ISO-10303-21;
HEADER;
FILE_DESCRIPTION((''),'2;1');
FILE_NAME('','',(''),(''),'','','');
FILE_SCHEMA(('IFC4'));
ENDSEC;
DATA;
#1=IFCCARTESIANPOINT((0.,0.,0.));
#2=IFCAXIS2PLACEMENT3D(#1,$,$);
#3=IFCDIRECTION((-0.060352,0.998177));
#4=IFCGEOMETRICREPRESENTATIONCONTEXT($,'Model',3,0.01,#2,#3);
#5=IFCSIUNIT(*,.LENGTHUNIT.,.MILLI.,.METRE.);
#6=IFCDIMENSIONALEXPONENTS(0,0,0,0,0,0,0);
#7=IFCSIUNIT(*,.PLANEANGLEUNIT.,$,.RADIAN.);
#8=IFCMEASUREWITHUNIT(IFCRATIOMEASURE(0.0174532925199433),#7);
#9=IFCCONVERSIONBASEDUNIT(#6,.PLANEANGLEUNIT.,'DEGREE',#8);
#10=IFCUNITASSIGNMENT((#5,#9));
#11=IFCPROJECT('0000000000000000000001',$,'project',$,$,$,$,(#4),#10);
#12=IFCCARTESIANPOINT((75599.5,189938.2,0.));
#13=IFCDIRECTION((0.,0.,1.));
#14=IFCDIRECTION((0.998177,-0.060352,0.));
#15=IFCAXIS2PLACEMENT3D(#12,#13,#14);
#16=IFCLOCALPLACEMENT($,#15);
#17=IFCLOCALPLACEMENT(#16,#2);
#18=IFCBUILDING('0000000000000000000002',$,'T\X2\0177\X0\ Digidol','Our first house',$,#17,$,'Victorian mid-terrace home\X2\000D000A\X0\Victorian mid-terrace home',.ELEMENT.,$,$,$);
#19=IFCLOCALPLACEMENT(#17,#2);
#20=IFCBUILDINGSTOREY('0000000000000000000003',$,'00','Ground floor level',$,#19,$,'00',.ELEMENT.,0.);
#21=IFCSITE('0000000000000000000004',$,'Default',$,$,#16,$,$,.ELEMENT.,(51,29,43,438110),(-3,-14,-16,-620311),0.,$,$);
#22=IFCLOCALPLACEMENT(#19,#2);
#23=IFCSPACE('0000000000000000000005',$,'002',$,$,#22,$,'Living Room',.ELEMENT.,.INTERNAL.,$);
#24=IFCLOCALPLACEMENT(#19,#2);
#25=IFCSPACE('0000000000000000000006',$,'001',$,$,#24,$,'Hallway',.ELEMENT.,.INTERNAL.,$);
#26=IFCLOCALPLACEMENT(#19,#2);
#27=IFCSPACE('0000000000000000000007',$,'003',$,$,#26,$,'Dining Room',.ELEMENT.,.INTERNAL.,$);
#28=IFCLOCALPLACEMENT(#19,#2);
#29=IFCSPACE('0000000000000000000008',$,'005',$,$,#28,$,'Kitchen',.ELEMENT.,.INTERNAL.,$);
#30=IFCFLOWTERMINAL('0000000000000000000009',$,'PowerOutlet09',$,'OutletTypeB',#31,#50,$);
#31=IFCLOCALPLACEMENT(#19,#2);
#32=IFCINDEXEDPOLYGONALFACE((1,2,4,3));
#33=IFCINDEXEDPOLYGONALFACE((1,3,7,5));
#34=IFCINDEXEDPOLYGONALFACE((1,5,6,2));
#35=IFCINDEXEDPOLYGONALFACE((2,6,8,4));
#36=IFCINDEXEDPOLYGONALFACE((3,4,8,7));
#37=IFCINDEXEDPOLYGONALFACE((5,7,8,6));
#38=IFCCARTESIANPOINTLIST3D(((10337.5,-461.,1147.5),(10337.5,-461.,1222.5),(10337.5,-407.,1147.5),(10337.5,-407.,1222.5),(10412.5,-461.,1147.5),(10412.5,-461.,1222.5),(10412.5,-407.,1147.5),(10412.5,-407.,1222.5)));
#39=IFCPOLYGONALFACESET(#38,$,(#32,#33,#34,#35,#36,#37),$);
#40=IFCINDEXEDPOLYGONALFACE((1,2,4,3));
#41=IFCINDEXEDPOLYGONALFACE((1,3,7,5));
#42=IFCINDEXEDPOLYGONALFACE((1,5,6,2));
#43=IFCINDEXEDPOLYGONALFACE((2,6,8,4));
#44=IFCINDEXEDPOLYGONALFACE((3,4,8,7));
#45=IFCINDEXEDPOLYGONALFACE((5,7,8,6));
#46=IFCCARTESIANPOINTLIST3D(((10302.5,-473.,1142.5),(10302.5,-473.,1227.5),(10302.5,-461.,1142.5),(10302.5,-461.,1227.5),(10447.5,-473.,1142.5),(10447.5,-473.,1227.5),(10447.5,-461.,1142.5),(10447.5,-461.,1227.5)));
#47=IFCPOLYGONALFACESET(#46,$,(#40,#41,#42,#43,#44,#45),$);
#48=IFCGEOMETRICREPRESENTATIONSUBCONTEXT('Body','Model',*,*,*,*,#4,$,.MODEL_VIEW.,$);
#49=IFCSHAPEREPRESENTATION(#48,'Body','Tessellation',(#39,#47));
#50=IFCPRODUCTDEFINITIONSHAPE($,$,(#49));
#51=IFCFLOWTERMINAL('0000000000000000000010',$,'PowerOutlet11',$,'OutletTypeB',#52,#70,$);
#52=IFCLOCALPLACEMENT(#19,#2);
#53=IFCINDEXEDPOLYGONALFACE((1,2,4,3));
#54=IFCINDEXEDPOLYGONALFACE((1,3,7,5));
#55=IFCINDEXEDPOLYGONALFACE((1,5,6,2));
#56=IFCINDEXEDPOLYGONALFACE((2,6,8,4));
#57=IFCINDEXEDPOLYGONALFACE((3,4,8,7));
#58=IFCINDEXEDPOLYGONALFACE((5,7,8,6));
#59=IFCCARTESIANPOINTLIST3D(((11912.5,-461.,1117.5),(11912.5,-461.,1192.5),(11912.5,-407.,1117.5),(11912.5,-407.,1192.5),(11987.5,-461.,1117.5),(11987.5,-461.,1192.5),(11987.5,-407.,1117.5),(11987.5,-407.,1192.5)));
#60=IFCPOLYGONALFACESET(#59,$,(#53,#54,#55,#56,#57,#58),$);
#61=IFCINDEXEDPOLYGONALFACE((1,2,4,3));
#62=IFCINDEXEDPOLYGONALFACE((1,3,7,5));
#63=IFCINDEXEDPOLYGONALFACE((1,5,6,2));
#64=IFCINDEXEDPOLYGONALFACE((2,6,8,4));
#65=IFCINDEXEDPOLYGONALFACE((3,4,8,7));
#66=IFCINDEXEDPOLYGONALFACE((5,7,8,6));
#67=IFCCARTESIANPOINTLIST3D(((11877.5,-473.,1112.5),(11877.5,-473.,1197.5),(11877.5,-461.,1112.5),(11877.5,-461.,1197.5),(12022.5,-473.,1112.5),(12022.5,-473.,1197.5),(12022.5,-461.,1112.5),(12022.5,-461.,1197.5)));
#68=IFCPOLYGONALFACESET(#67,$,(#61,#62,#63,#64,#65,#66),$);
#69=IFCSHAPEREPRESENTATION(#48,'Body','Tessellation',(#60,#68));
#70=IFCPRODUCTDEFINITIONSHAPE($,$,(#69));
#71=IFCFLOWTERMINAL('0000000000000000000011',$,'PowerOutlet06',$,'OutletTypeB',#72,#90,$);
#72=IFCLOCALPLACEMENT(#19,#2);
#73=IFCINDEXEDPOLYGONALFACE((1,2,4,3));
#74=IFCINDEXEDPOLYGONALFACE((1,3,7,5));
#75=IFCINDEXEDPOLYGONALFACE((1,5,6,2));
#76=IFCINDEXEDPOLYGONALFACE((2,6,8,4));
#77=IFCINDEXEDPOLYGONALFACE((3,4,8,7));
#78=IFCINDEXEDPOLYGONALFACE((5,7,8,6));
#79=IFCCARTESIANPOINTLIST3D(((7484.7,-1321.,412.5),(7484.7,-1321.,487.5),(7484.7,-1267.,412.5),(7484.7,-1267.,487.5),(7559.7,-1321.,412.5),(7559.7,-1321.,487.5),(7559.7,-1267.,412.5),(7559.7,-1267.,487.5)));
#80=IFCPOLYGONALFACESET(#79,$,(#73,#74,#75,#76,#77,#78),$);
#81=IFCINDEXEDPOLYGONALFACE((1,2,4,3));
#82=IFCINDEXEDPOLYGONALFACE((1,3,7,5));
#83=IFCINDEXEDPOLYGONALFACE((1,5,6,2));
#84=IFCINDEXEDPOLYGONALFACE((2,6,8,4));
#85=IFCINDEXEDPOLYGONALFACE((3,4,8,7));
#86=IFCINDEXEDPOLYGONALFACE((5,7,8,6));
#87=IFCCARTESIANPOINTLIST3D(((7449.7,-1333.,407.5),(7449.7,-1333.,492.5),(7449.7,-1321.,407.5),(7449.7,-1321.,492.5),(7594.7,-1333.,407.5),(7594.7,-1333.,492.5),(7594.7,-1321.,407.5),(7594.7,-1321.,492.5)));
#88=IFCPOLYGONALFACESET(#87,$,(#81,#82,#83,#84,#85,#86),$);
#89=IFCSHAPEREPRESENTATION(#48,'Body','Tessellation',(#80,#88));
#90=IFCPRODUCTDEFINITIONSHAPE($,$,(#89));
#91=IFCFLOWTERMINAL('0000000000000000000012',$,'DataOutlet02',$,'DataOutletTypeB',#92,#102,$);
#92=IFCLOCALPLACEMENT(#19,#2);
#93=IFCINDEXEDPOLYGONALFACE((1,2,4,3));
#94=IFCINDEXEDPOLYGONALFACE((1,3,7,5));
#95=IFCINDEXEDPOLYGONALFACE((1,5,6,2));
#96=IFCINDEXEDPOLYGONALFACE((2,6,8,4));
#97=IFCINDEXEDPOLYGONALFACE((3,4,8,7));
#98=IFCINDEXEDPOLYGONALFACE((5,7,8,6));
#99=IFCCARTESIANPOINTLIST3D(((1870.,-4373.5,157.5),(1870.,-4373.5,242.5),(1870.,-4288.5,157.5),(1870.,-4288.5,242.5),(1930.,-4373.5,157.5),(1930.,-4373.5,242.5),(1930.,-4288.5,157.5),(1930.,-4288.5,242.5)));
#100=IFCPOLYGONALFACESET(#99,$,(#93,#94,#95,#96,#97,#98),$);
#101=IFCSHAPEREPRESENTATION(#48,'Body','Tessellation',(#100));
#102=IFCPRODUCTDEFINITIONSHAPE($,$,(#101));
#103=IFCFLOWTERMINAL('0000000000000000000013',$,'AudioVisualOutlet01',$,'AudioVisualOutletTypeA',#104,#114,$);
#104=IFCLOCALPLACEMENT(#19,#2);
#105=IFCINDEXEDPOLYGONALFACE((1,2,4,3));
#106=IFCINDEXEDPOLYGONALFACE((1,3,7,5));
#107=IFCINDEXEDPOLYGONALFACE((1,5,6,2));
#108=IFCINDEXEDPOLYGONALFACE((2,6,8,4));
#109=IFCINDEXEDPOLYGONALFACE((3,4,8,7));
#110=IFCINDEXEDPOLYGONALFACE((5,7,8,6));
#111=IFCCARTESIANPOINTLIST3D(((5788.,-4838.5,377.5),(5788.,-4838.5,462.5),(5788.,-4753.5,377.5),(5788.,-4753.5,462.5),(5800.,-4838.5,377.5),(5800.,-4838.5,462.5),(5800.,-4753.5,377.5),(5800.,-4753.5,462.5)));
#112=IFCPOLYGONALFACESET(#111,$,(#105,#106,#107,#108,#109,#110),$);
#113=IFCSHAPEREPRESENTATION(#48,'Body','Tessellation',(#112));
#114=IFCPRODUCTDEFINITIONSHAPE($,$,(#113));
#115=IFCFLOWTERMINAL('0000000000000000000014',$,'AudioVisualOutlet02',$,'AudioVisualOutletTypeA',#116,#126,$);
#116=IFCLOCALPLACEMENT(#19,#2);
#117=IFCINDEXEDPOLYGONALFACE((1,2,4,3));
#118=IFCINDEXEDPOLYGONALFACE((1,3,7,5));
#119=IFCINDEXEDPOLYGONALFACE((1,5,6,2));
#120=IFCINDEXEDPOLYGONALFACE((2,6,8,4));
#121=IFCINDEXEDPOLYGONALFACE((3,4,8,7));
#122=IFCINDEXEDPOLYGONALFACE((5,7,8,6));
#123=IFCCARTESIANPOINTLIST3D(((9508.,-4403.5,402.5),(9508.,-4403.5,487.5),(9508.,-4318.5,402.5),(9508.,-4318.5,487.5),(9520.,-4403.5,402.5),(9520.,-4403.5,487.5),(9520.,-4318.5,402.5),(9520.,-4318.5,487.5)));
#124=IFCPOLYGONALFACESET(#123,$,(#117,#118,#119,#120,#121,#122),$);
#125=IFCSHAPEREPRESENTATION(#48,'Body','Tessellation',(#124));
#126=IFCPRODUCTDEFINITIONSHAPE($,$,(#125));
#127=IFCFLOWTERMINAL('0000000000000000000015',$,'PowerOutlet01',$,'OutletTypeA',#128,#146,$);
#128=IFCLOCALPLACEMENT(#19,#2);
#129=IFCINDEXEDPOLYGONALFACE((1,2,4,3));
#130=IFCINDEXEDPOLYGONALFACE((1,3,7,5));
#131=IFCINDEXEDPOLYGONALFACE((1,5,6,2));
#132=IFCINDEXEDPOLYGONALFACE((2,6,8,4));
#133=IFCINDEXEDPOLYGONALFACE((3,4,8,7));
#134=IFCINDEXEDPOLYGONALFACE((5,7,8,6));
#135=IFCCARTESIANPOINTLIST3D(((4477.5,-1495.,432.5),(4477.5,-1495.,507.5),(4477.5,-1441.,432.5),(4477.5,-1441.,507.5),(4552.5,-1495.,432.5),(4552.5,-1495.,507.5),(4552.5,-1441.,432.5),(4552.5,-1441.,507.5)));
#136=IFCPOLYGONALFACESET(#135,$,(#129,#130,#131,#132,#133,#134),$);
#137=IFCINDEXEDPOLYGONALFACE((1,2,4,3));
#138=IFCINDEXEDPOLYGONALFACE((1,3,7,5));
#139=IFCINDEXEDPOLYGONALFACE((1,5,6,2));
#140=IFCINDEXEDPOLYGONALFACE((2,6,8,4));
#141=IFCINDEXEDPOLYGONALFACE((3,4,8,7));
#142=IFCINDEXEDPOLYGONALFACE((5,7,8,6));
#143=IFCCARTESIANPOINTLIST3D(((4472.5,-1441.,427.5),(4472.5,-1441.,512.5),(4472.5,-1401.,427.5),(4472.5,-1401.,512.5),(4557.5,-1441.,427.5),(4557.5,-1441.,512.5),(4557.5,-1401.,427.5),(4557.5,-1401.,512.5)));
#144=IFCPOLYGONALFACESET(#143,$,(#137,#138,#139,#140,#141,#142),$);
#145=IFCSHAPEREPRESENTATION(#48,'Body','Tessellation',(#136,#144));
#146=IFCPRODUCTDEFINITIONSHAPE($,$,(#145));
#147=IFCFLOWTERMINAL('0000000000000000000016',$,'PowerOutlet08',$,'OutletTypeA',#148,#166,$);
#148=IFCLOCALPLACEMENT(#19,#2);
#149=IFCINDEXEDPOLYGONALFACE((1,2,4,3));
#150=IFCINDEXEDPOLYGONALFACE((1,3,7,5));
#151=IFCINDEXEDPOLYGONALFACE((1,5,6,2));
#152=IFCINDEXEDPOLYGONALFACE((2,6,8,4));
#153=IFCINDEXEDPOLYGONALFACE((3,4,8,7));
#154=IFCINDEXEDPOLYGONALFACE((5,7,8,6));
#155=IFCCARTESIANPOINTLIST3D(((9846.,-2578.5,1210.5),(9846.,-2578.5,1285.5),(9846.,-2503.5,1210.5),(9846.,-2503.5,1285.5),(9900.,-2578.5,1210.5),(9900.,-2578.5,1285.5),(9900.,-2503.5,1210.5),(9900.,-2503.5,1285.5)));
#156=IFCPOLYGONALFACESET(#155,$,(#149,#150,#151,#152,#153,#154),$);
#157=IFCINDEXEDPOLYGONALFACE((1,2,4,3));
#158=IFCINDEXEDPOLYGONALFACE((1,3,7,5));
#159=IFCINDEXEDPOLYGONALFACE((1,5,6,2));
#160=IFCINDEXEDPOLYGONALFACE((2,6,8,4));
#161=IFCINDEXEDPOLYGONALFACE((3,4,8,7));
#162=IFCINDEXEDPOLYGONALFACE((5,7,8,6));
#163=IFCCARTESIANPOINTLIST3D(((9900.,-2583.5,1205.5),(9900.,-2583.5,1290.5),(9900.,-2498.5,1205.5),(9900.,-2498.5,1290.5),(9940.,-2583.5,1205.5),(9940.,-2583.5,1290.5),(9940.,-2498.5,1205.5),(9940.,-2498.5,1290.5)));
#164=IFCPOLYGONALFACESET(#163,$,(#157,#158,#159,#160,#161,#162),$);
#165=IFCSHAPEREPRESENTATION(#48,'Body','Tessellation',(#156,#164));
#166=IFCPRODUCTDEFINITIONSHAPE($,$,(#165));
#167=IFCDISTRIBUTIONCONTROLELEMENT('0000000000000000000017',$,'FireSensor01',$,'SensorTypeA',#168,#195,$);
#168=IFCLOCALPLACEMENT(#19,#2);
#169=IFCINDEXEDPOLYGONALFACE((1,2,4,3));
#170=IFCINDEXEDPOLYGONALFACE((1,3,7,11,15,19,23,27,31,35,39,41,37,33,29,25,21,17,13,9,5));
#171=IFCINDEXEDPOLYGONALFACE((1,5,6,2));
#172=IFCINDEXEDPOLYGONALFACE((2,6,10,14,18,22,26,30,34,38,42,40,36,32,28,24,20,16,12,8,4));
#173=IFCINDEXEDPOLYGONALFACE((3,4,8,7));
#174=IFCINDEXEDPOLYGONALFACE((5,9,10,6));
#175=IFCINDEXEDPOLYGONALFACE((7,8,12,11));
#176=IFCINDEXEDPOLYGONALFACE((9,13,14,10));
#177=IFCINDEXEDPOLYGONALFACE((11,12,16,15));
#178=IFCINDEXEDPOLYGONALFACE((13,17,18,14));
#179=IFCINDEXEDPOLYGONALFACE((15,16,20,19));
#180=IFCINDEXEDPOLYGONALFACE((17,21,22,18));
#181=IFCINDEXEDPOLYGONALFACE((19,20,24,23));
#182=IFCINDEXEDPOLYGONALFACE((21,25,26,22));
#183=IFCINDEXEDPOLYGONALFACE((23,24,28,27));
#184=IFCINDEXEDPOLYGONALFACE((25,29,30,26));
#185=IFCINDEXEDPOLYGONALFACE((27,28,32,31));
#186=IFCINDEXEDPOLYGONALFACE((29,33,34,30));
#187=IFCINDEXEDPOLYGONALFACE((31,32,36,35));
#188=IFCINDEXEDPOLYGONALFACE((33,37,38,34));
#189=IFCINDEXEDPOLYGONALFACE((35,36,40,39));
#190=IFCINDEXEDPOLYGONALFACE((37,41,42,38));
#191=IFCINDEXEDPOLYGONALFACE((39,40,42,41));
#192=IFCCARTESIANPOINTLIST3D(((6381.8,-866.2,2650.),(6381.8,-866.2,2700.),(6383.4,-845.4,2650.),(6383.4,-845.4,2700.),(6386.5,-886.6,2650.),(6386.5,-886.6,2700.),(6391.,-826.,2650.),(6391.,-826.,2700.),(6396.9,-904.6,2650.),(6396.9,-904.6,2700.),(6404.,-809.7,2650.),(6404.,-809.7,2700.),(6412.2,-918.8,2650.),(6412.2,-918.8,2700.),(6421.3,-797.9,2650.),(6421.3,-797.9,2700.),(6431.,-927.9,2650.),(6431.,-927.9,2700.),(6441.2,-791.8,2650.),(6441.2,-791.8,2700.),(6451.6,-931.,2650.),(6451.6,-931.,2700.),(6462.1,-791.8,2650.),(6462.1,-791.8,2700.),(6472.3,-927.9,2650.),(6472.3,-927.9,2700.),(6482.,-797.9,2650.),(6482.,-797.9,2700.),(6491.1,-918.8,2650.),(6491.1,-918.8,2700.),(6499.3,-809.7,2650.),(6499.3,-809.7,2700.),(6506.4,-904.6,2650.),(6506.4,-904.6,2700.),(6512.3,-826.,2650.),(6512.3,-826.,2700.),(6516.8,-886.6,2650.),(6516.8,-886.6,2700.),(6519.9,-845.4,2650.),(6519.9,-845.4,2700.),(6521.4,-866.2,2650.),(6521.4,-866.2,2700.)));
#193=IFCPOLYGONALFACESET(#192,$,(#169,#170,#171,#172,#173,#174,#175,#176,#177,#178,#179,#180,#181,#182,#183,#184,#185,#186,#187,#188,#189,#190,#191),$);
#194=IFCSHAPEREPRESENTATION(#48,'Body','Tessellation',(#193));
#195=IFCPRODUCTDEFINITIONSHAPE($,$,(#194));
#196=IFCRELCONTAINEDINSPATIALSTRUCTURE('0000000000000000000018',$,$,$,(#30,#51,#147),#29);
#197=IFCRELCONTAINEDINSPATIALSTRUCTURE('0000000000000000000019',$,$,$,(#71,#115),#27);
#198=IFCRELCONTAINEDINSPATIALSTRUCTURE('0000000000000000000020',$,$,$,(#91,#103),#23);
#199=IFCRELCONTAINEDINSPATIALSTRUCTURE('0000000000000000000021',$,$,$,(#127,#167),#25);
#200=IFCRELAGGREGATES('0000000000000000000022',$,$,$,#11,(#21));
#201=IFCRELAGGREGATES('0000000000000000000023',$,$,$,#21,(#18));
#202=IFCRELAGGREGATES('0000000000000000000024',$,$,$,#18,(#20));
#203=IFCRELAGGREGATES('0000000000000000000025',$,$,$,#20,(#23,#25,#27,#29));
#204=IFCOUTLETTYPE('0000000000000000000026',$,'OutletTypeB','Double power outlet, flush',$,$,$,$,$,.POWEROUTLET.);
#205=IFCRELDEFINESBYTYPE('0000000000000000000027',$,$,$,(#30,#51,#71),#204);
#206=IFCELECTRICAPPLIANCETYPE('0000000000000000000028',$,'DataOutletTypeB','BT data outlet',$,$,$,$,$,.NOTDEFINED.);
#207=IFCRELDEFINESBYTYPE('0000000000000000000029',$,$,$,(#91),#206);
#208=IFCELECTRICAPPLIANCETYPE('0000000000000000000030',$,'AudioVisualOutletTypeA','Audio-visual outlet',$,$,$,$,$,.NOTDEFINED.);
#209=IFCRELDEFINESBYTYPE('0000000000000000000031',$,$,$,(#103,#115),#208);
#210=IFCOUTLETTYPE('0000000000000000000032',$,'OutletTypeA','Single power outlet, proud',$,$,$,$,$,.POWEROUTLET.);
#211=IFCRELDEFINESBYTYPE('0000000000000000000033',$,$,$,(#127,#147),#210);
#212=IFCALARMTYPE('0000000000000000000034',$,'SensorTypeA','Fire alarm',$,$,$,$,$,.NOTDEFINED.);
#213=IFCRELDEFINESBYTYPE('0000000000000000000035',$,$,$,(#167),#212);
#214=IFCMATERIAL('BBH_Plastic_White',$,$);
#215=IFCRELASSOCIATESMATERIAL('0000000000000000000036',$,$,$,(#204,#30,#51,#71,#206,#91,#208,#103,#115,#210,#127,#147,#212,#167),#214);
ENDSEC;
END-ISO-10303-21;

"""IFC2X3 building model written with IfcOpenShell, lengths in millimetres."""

from ifc_helpers import new_model, entity, si_unit, converted_unit, direction, frame, frame_2d, origin, origin_2d_with_axis, place, context, subcontext, project, spatial, rectangle, circle, extrude, source, transform, mapped, material, type_object, type_shapes, element, save


model = new_model("IFC2X3")

# Units and contexts
model_context = context("Model", 3, precision=0.01, world=origin(), true_north=direction((-0.060352, 0.998177)))
body_context = subcontext(model_context, "Body", "Model", "MODEL_VIEW")
ifc_project = project(units=[si_unit("LENGTHUNIT", "METRE", prefix="MILLI"), converted_unit("PLANEANGLEUNIT", "DEGREE", entity("IfcRatioMeasure", 0.0174532925199433), si_unit("PLANEANGLEUNIT", "RADIAN"), dimensions=[0, 0, 0, 0, 0, 0, 0])], contexts=[model_context])

# Site, building, storey
site_placement = place(None, frame((75599.5, 189938.2, 0.0), z_axis=(0.0, 0.0, 1.0), x_axis=(0.998177, -0.060352, 0.0)))
site = spatial("IfcSite", under=ifc_project, at=site_placement, Name="Default", CompositionType="ELEMENT", RefLatitude=(51, 29, 43, 438110), RefLongitude=(-3, -14, -16, -620311), RefElevation=0.0)
building_placement = place(site_placement, origin())
building = spatial("IfcBuilding", under=site, at=building_placement, Name="Tŷ Digidol", Description="Our first house", LongName="Victorian mid-terrace home\r\nVictorian mid-terrace home", CompositionType="ELEMENT")
storey_placement = place(building_placement, origin())
storey = spatial("IfcBuildingStorey", under=building, at=storey_placement, Name="00", Description="Ground floor level", LongName="00", CompositionType="ELEMENT", Elevation=0.0)

# Shared definitions
space_1_placement = place(storey_placement, origin())
space_1 = spatial("IfcSpace", under=storey, at=space_1_placement, Name="002", LongName="Living Room", CompositionType="ELEMENT", InteriorOrExteriorSpace="INTERNAL")

# Shared definitions
ifc_material_1 = material(Name="BBH_Plastic_White")

# Shared definitions
space_2_placement = place(storey_placement, origin())
space_2 = spatial("IfcSpace", under=storey, at=space_2_placement, Name="001", LongName="Hallway", CompositionType="ELEMENT", InteriorOrExteriorSpace="INTERNAL")

# Shared definitions
space_3_placement = place(storey_placement, origin())
space_3 = spatial("IfcSpace", under=storey, at=space_3_placement, Name="003", LongName="Dining Room", CompositionType="ELEMENT", InteriorOrExteriorSpace="INTERNAL")

# Shared definitions
outlet_type_1 = type_object("IfcOutletType", Name="OutletTypeB", Description="Double power outlet, flush", PredefinedType="POWEROUTLET", material=ifc_material_1)
shared_shape_1 = source(origin(), body_context, "Body", "SweptSolid", [
    extrude(rectangle(XDim=75.0, YDim=75.0, at=origin_2d_with_axis()), frame((0.0, 0.0, -54.0), z_axis=(0.0, 0.0, 1.0), x_axis=(-1.0, 0.0, 0.0)), (0.0, 0.0, 1.0), 54.0),
    extrude(rectangle(XDim=145.0, YDim=85.0, at=origin_2d_with_axis()), frame((0.0, 0.0, 0.0), z_axis=(0.0, 0.0, 1.0), x_axis=(-1.0, 0.0, 0.0)), (0.0, 0.0, 1.0), 12.0),
])
type_shapes(outlet_type_1, [shared_shape_1])

# Shared definitions
space_4_placement = place(storey_placement, origin())
space_4 = spatial("IfcSpace", under=storey, at=space_4_placement, Name="005", LongName="Kitchen", CompositionType="ELEMENT", InteriorOrExteriorSpace="INTERNAL")

# Flow terminals
for number, where, z_axis, x_axis, name in (
    (1, (10375.0, -461.0, 1185.0), (0.0, -1.0, 0.0), (1.0, 0.0, 0.0), "PowerOutlet09"),
    (2, (11950.0, -461.0, 1155.0), (0.0, -1.0, 0.0), (1.0, 0.0, 0.0), "PowerOutlet11"),
):
    element("IfcFlowTerminal", number, at=place(space_4_placement, frame(where, z_axis=z_axis, x_axis=x_axis)), inside=space_4, type_object=outlet_type_1, material=ifc_material_1, Name=name, ObjectType="OutletTypeB", context=body_context, shape_type="MappedRepresentation", body=[
        mapped(shared_shape_1, transform((0.0, 0.0, 0.0), scale=1.0)),
    ])
flow_terminal_1_placement = place(space_3_placement, frame((7522.2, -1321.0, 450.0), z_axis=(0.0, -1.0, 0.0), x_axis=(1.0, 0.0, 0.0)))
element("IfcFlowTerminal", 3, at=flow_terminal_1_placement, inside=space_3, type_object=outlet_type_1, material=ifc_material_1, Name="PowerOutlet06", ObjectType="OutletTypeB", context=body_context, shape_type="MappedRepresentation", body=[
    mapped(shared_shape_1, transform((0.0, 0.0, 0.0), scale=1.0)),
])
electric_appliance_type_1 = type_object("IfcElectricApplianceType", Name="DataOutletTypeB", Description="BT data outlet", PredefinedType="NOTDEFINED", material=ifc_material_1)
shared_shape_2 = source(origin(), body_context, "Body", "SweptSolid", [
    extrude(rectangle(XDim=85.0, YDim=85.0, at=origin_2d_with_axis()), frame((0.0, 0.0, 0.0), z_axis=(0.0, 0.0, 1.0), x_axis=(-1.0, 0.0, 0.0)), (0.0, 0.0, 1.0), 60.0),
])
type_shapes(electric_appliance_type_1, [shared_shape_2])
flow_terminal_2_placement = place(space_1_placement, frame((1870.0, -4331.0, 200.0), z_axis=(1.0, 0.0, 0.0), x_axis=(0.0, 1.0, 0.0)))
element("IfcFlowTerminal", 4, at=flow_terminal_2_placement, inside=space_1, type_object=electric_appliance_type_1, material=ifc_material_1, Name="DataOutlet02", ObjectType="DataOutletTypeB", context=body_context, shape_type="MappedRepresentation", body=[
    mapped(shared_shape_2, transform((0.0, 0.0, 0.0), scale=1.0)),
])
electric_appliance_type_2 = type_object("IfcElectricApplianceType", Name="AudioVisualOutletTypeA", Description="Audio-visual outlet", PredefinedType="NOTDEFINED", material=ifc_material_1)
shared_shape_3 = source(origin(), body_context, "Body", "SweptSolid", [
    extrude(rectangle(XDim=85.0, YDim=85.0, at=origin_2d_with_axis()), frame((0.0, 0.0, 0.0), z_axis=(0.0, 0.0, 1.0), x_axis=(-1.0, 0.0, 0.0)), (0.0, 0.0, 1.0), 12.0),
])
type_shapes(electric_appliance_type_2, [shared_shape_3])
flow_terminal_3_placement = place(space_1_placement, frame((5800.0, -4796.0, 420.0), z_axis=(-1.0, 0.0, 0.0), x_axis=(0.0, -1.0, 0.0)))
element("IfcFlowTerminal", 5, at=flow_terminal_3_placement, inside=space_1, type_object=electric_appliance_type_2, material=ifc_material_1, Name="AudioVisualOutlet01", ObjectType="AudioVisualOutletTypeA", context=body_context, shape_type="MappedRepresentation", body=[
    mapped(shared_shape_3, transform((0.0, 0.0, 0.0), scale=1.0)),
])
flow_terminal_4_placement = place(space_3_placement, frame((9520.0, -4361.0, 445.0), z_axis=(-1.0, 0.0, 0.0), x_axis=(0.0, -1.0, 0.0)))
element("IfcFlowTerminal", 6, at=flow_terminal_4_placement, inside=space_3, type_object=electric_appliance_type_2, material=ifc_material_1, Name="AudioVisualOutlet02", ObjectType="AudioVisualOutletTypeA", context=body_context, shape_type="MappedRepresentation", body=[
    mapped(shared_shape_3, transform((0.0, 0.0, 0.0), scale=1.0)),
])
outlet_type_2 = type_object("IfcOutletType", Name="OutletTypeA", Description="Single power outlet, proud", PredefinedType="POWEROUTLET", material=ifc_material_1)
shared_shape_4 = source(origin(), body_context, "Body", "SweptSolid", [
    extrude(rectangle(XDim=75.0, YDim=75.0, at=origin_2d_with_axis()), frame((0.0, 0.0, -54.0), z_axis=(0.0, 0.0, 1.0), x_axis=(-1.0, 0.0, 0.0)), (0.0, 0.0, 1.0), 54.0),
    extrude(rectangle(XDim=85.0, YDim=85.0, at=origin_2d_with_axis()), frame((0.0, 0.0, 0.0), z_axis=(0.0, 0.0, 1.0), x_axis=(-1.0, 0.0, 0.0)), (0.0, 0.0, 1.0), 40.0),
])
type_shapes(outlet_type_2, [shared_shape_4])
flow_terminal_5_placement = place(space_2_placement, frame((4515.0, -1441.0, 470.0), z_axis=(0.0, 1.0, 0.0), x_axis=(-1.0, 0.0, 0.0)))
element("IfcFlowTerminal", 7, at=flow_terminal_5_placement, inside=space_2, type_object=outlet_type_2, material=ifc_material_1, Name="PowerOutlet01", ObjectType="OutletTypeA", context=body_context, shape_type="MappedRepresentation", body=[
    mapped(shared_shape_4, transform((0.0, 0.0, 0.0), scale=1.0)),
])
flow_terminal_6_placement = place(space_4_placement, frame((9900.0, -2541.0, 1248.0), z_axis=(1.0, 0.0, 0.0), x_axis=(0.0, -1.0, 0.0)))
element("IfcFlowTerminal", 8, at=flow_terminal_6_placement, inside=space_4, type_object=outlet_type_2, material=ifc_material_1, Name="PowerOutlet08", ObjectType="OutletTypeA", context=body_context, shape_type="MappedRepresentation", body=[
    mapped(shared_shape_4, transform((0.0, 0.0, 0.0), scale=1.0)),
])

# Distribution control element
alarm_type_1 = type_object("IfcAlarmType", Name="SensorTypeA", Description="Fire alarm", PredefinedType="NOTDEFINED", material=ifc_material_1)
shared_shape_5 = source(origin(), body_context, "Body", "SweptSolid", [
    extrude(circle(Radius=70.0, at=frame_2d((0.0, 0.0), x_axis=(1.0, 0.0))), origin(), (0.0, 0.0, 1.0), 50.0),
])
type_shapes(alarm_type_1, [shared_shape_5])
distribution_control_element_1_placement = place(space_2_placement, frame((6451.6, -861.0, 2700.0), z_axis=(0.0, 0.0, -1.0), x_axis=(0.0, -1.0, 0.0)))
element("IfcDistributionControlElement", 9, at=distribution_control_element_1_placement, inside=space_2, type_object=alarm_type_1, material=ifc_material_1, Name="FireSensor01", ObjectType="SensorTypeA", context=body_context, shape_type="MappedRepresentation", body=[
    mapped(shared_shape_5, transform((0.0, 0.0, 0.0), scale=1.0)),
])

save(model, "model.ifc")
